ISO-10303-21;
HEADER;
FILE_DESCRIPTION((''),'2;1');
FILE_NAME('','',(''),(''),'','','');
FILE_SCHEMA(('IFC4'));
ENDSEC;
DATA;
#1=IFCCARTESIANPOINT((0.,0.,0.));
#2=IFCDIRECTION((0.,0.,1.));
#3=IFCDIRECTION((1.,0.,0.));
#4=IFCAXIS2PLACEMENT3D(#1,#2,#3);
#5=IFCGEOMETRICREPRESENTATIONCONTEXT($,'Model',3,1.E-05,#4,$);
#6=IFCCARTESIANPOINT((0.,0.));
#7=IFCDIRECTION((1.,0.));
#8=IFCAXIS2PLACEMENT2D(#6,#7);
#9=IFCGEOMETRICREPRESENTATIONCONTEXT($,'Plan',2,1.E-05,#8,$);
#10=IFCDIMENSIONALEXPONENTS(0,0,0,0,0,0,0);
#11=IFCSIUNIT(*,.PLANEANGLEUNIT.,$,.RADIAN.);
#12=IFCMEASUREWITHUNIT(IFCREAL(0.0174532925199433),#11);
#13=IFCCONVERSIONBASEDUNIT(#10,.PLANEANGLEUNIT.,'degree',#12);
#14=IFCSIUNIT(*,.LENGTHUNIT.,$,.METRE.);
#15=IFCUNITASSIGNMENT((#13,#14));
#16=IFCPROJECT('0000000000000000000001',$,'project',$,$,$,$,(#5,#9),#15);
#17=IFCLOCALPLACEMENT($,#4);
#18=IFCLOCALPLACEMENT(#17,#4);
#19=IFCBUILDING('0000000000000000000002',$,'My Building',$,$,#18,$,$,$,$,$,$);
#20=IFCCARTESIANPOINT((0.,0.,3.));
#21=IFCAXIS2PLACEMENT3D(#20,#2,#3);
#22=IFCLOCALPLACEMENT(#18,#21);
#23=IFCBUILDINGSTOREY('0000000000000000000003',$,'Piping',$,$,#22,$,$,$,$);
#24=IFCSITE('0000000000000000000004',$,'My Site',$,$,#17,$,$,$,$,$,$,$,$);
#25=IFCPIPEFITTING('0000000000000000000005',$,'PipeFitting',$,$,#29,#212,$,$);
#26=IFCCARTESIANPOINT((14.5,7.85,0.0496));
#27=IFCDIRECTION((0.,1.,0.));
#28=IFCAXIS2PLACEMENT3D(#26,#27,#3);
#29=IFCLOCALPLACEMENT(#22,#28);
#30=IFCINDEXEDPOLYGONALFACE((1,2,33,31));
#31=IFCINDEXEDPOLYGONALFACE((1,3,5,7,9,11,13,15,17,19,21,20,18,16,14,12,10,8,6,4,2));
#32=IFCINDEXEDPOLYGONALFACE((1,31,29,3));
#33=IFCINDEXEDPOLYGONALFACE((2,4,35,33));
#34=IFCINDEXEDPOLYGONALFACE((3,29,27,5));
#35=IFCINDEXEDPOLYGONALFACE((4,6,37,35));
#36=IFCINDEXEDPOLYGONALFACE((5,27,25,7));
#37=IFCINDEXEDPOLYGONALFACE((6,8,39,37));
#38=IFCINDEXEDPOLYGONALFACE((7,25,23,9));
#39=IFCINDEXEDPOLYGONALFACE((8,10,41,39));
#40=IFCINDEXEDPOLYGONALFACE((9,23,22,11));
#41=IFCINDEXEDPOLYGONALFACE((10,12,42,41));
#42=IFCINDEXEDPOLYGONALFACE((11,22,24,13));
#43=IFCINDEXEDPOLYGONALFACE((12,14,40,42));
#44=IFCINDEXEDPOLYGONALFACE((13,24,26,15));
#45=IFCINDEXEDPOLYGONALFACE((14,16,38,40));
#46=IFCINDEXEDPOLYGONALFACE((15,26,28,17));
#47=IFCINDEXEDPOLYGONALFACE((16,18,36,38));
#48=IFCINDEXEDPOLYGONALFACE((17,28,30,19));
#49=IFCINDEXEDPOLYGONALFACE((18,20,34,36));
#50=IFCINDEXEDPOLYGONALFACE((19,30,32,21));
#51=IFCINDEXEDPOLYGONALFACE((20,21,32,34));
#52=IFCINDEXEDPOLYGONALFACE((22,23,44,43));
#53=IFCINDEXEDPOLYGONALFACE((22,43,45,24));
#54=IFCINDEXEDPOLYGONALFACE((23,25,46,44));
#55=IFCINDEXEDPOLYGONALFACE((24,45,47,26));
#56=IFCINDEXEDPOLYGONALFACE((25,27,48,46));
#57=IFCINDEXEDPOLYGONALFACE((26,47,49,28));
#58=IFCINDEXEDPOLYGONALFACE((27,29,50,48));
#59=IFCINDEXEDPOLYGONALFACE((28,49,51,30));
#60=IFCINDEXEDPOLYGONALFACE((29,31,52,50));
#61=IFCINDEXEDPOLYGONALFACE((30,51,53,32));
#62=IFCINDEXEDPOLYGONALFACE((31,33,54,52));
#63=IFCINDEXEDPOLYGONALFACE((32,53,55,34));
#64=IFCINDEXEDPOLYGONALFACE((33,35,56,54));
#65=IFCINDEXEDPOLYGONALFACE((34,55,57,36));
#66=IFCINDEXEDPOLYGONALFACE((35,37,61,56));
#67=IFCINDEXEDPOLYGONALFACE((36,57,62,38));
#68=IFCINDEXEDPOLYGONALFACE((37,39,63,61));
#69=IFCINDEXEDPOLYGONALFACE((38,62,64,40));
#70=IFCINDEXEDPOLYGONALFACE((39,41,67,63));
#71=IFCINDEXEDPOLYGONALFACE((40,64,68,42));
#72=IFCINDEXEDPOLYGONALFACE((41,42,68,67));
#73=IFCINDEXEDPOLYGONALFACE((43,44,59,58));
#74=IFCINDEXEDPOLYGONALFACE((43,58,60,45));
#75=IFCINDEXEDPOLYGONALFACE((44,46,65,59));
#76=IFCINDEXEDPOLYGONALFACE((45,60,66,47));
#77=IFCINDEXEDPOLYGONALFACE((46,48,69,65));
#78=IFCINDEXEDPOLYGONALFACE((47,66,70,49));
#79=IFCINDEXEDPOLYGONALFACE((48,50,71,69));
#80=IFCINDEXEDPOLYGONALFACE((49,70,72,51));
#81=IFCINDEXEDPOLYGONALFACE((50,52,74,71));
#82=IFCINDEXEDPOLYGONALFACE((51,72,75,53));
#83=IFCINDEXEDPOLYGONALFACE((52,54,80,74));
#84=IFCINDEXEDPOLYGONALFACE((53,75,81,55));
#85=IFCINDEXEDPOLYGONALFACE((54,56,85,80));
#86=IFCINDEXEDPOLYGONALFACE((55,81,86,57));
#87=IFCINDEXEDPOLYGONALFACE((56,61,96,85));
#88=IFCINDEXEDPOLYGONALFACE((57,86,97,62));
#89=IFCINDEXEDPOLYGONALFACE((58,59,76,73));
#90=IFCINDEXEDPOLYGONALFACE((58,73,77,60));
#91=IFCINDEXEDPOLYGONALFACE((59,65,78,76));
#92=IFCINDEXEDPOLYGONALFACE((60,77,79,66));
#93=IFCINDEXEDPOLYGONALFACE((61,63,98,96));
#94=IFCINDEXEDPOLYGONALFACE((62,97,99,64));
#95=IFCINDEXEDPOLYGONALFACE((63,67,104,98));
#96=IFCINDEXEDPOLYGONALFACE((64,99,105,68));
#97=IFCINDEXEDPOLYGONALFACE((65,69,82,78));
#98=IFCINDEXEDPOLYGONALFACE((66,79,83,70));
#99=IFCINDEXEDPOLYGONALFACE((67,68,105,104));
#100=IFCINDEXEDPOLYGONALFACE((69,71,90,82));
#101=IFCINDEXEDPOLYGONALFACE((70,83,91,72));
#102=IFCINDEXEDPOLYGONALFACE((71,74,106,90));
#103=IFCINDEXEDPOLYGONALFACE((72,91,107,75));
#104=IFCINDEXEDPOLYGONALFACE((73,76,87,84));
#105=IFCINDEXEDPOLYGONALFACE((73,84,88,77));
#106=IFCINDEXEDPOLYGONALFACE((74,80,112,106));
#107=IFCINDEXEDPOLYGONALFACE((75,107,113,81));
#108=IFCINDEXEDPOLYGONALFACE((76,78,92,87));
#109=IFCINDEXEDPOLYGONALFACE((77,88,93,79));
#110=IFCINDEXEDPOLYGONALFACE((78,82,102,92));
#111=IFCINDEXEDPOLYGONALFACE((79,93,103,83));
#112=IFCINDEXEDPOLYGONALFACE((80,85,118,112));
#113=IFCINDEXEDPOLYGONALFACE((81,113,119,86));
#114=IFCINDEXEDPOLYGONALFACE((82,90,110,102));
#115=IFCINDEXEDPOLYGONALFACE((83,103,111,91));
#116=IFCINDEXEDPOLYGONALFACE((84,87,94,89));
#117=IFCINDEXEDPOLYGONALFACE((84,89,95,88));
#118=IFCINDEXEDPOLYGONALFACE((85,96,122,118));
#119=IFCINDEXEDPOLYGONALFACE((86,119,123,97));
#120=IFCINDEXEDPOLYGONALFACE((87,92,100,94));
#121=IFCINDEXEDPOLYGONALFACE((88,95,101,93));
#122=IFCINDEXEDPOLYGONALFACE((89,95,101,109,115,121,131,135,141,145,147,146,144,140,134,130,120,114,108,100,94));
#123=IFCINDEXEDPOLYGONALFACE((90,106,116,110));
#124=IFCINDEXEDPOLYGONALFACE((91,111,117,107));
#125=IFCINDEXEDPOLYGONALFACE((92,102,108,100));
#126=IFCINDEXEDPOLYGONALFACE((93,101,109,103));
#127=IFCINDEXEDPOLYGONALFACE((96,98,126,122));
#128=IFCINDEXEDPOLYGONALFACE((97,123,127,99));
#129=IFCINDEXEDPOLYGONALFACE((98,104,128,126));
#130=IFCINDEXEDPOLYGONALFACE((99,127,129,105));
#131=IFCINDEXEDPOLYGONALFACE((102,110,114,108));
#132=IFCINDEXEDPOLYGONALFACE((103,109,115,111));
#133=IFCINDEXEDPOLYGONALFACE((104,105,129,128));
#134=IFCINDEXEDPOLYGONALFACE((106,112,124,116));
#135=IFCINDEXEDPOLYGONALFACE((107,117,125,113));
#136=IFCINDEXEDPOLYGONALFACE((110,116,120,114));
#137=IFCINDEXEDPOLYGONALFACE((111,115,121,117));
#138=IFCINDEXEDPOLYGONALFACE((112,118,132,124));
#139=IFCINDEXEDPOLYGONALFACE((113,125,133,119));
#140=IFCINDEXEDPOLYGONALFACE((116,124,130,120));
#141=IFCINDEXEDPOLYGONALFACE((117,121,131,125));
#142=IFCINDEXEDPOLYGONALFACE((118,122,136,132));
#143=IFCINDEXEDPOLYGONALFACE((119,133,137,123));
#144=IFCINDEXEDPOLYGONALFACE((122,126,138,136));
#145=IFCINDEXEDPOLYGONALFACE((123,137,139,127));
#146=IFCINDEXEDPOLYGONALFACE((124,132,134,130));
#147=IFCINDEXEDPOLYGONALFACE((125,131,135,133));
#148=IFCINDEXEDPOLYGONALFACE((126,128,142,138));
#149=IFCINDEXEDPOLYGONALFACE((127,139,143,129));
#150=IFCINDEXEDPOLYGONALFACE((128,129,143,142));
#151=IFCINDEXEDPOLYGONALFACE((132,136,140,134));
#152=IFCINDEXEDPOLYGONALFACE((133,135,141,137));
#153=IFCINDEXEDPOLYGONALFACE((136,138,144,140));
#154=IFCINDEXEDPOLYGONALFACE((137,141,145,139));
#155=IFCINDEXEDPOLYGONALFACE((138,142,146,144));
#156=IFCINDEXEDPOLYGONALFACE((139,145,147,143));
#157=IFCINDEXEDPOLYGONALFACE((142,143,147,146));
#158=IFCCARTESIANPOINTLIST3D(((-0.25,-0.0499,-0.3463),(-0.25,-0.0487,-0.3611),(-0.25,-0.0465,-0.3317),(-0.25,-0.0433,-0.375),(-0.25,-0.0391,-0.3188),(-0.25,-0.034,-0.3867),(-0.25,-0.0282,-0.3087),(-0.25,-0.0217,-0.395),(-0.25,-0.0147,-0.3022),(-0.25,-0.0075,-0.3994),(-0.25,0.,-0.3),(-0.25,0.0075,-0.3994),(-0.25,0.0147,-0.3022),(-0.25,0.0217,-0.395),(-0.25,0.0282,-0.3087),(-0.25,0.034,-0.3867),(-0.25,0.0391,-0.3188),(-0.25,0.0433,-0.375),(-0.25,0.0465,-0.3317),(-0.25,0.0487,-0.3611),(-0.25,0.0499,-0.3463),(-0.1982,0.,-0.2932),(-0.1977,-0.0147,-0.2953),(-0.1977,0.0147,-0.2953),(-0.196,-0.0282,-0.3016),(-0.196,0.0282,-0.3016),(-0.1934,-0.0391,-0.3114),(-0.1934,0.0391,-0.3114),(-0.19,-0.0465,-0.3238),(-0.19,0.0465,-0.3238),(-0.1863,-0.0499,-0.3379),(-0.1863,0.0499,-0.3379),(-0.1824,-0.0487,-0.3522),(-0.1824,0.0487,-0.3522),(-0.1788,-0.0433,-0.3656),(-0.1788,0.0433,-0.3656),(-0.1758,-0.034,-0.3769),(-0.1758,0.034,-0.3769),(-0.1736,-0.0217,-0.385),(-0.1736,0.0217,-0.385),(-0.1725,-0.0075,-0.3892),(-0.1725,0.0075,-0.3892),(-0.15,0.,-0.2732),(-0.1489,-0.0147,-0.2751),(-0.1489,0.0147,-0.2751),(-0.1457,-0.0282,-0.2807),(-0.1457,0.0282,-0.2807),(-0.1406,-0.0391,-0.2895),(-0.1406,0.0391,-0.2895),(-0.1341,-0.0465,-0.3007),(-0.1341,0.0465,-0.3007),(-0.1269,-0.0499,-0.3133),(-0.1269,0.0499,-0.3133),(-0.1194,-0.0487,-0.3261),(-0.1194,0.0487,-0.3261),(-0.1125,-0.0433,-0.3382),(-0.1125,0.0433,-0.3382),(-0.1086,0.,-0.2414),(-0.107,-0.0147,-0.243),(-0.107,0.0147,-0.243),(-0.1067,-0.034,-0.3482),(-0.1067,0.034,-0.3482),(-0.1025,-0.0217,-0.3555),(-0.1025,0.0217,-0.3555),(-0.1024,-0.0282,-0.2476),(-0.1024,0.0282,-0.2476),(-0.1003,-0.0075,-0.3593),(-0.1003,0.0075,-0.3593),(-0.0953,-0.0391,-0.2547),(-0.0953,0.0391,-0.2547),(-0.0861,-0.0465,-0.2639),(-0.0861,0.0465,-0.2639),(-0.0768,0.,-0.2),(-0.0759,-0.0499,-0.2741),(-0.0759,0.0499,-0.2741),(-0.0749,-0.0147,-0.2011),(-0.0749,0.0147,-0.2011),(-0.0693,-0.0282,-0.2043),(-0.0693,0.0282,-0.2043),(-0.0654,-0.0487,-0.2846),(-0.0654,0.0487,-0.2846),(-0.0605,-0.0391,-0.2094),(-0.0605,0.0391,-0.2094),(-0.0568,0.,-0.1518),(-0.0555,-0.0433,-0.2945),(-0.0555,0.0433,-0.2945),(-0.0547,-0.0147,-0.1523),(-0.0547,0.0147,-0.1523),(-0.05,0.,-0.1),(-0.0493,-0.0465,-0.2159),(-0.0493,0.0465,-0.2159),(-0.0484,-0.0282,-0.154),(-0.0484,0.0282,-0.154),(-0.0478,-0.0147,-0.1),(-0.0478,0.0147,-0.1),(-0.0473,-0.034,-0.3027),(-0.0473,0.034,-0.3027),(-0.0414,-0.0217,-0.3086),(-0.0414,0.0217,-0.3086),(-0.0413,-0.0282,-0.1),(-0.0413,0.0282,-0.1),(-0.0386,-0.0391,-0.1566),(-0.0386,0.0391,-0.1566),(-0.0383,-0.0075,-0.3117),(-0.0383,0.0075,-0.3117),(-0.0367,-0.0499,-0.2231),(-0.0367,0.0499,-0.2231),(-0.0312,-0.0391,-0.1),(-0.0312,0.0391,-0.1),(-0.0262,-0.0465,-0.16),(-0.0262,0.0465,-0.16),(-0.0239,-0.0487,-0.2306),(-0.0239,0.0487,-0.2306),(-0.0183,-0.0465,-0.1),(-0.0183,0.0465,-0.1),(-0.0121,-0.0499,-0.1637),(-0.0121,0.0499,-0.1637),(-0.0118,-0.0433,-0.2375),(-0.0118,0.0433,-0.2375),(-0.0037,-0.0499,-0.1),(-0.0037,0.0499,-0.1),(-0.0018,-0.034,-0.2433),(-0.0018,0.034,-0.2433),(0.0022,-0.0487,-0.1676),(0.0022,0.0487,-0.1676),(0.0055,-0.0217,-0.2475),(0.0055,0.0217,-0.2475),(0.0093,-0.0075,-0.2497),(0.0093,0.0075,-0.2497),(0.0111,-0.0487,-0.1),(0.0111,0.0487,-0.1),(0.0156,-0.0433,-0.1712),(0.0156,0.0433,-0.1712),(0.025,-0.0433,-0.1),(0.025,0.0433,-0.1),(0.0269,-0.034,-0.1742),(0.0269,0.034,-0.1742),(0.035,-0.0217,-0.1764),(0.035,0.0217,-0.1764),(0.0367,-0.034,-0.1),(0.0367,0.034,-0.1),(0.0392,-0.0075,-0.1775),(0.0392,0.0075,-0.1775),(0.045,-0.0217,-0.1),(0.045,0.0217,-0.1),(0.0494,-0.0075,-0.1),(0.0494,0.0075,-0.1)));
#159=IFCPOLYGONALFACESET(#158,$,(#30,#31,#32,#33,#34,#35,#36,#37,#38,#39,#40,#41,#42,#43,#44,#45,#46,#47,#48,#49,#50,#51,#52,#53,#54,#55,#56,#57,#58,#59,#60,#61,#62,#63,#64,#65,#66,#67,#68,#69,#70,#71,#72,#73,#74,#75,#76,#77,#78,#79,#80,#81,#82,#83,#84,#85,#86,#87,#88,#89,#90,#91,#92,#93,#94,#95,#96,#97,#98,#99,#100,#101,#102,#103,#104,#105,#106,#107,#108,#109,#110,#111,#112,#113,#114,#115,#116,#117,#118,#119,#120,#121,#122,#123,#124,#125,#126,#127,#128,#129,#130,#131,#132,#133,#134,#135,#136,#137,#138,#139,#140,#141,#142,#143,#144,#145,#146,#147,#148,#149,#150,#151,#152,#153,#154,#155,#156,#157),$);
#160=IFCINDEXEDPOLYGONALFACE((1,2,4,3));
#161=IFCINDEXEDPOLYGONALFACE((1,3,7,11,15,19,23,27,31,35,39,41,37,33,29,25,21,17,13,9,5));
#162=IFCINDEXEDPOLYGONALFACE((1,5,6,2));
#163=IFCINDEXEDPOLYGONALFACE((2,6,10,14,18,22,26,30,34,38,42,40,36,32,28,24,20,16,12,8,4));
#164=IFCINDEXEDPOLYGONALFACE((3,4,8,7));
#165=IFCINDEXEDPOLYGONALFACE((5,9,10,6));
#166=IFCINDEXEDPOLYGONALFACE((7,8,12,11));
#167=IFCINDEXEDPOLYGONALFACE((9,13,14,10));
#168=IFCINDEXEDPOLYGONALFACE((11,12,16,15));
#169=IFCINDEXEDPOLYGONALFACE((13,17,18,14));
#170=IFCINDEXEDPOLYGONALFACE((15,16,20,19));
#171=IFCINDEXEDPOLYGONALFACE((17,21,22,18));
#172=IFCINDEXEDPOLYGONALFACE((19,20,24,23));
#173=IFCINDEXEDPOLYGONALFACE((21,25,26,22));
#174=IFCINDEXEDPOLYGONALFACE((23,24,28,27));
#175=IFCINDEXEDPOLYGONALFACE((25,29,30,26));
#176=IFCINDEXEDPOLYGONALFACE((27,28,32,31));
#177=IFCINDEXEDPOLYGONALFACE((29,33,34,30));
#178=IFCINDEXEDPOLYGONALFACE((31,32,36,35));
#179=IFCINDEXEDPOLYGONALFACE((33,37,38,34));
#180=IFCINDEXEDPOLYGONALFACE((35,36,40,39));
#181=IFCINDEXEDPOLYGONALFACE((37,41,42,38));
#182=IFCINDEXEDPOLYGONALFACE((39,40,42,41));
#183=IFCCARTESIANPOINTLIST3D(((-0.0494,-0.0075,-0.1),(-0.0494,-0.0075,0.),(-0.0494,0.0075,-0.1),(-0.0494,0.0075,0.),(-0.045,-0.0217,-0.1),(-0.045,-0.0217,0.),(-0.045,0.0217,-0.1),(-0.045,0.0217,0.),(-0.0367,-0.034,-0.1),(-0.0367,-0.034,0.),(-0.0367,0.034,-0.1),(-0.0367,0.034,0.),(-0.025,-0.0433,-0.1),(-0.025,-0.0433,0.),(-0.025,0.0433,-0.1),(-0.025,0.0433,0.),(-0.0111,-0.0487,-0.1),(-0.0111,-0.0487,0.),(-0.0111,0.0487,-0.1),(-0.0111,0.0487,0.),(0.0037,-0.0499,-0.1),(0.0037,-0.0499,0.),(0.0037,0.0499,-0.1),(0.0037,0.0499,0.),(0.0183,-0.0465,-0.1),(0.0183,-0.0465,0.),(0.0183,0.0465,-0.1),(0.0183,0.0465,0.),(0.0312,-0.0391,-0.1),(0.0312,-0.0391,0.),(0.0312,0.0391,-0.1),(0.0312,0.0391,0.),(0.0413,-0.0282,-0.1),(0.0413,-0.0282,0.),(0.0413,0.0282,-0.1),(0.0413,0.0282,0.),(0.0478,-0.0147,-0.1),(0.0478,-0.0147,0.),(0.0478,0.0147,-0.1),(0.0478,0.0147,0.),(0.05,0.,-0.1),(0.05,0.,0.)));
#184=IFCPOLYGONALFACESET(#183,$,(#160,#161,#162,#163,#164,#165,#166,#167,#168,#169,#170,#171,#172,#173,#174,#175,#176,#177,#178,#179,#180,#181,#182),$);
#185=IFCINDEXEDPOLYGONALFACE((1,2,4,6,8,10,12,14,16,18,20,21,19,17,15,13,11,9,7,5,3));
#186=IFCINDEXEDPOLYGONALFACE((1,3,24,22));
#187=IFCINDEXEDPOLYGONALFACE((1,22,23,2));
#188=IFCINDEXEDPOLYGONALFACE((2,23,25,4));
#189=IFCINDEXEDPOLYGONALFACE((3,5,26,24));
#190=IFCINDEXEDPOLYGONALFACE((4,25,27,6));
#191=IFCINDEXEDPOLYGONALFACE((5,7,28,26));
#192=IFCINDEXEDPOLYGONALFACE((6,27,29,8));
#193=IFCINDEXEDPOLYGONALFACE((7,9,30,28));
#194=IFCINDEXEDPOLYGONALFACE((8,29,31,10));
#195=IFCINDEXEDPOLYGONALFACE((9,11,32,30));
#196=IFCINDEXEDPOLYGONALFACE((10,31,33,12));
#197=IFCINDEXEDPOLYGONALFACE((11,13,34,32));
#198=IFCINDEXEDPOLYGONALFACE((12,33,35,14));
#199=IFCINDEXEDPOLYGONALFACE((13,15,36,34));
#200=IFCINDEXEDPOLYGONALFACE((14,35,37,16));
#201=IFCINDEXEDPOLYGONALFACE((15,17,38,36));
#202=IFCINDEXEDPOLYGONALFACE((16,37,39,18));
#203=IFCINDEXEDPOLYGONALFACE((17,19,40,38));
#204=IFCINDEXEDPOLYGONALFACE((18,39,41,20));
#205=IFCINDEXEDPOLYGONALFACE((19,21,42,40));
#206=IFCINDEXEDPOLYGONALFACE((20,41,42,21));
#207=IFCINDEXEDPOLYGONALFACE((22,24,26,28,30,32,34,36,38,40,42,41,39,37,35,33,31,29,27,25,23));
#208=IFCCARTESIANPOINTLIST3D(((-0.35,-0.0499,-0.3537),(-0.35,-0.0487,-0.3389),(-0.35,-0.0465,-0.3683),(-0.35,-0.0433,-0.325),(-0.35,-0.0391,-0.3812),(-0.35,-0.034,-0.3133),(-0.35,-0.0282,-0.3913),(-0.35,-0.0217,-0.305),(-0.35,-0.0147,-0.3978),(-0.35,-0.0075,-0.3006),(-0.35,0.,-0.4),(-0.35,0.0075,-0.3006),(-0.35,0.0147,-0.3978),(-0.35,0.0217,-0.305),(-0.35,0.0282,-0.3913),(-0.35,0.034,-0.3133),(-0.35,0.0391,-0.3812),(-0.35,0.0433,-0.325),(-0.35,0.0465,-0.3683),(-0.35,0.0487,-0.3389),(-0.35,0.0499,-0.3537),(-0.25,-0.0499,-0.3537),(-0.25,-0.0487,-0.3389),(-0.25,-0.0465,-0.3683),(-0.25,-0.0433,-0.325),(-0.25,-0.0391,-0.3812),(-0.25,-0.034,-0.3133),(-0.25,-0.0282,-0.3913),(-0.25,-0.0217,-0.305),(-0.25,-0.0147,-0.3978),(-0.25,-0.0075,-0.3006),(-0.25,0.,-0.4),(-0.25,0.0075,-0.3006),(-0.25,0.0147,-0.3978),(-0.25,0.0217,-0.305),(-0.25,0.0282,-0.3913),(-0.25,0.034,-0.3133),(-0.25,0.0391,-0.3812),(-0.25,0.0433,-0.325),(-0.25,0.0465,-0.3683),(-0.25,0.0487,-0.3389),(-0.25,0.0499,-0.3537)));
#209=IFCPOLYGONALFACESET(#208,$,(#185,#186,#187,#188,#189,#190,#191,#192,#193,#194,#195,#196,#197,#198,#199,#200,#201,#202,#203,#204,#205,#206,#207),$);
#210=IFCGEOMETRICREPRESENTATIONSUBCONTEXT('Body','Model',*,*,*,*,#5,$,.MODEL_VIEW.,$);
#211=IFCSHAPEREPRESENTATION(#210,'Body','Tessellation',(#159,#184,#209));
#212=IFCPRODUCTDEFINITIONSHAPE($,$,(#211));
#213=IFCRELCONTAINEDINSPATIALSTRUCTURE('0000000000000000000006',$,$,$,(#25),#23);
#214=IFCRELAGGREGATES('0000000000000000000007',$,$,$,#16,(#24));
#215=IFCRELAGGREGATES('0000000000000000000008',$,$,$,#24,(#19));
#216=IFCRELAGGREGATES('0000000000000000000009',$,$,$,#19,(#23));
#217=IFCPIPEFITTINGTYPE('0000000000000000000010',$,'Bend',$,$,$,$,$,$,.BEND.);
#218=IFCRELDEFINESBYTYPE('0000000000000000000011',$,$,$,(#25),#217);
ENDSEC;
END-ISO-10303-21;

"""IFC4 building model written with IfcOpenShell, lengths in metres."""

from ifc_helpers import new_model, entity, si_unit, converted_unit, frame, origin_with_axes, origin_2d_with_axis, place, context, subcontext, project, spatial, circle, extrude, source, transform, mapped, type_object, type_shapes, element, save


model = new_model("IFC4")

# Units and contexts
model_context = context("Model", 3, precision=1e-05, world=origin_with_axes())
plan_context = context("Plan", 2, precision=1e-05, world=origin_2d_with_axis())
body_context = subcontext(model_context, "Body", "Model", "MODEL_VIEW")
ifc_project = project(units=[converted_unit("PLANEANGLEUNIT", "degree", entity("IfcReal", 0.0174532925199433), si_unit("PLANEANGLEUNIT", "RADIAN"), dimensions=[0, 0, 0, 0, 0, 0, 0]), si_unit("LENGTHUNIT", "METRE")], contexts=[model_context, plan_context])

# Site, building, storey
site_placement = place(None, origin_with_axes())
site = spatial("IfcSite", under=ifc_project, at=site_placement, Name="My Site")
building_placement = place(site_placement, origin_with_axes())
building = spatial("IfcBuilding", under=site, at=building_placement, Name="My Building")
storey_placement = place(building_placement, frame((0.0, 0.0, 3.0), z_axis=(0.0, 0.0, 1.0), x_axis=(1.0, 0.0, 0.0)))
storey = spatial("IfcBuildingStorey", under=building, at=storey_placement, Name="Piping")

# Pipe fitting
pipe_fitting_type_1 = type_object("IfcPipeFittingType", Name="Bend", PredefinedType="BEND")
shared_shape = source(origin_with_axes(), body_context, "Body", "SolidModel", [
    entity("IfcSweptDiskSolid", entity("IfcIndexedPolyCurve", entity("IfcCartesianPointList3D", [[0.0, 0.0, -0.1], [-0.0732, 0.0, -0.2768], [-0.25, 0.0, -0.35]]), [entity("IfcArcIndex", [1, 2, 3])]), 0.05),
    extrude(circle(Radius=0.05), origin_with_axes(), (0.0, 0.0, -1.0), 0.1),
    extrude(circle(Radius=0.05), frame((-0.25, 0.0, -0.35), z_axis=(-1.0, 0.0, 0.0), x_axis=(0.0, 0.0, -1.0)), (0.0, 0.0, 1.0), 0.1),
])
type_shapes(pipe_fitting_type_1, [shared_shape])
for number, where, z_axis, x_axis, name in (
    (1, (14.5, 7.85, 0.0496), (0.0, 1.0, 0.0), (1.0, 0.0, 0.0), "PipeFitting"),
):
    element("IfcPipeFitting", number, at=place(storey_placement, frame(where, z_axis=z_axis, x_axis=x_axis)), inside=storey, type_object=pipe_fitting_type_1, Name=name, context=body_context, shape_type="MappedRepresentation", body=[
        mapped(shared_shape, transform((0.0, 0.0, 0.0), x_axis=(1.0, 0.0, 0.0), y_axis=(0.0, 1.0, 0.0), z_axis=(0.0, 0.0, 1.0), scale=1.0)),
    ])

save(model, "model.ifc")
